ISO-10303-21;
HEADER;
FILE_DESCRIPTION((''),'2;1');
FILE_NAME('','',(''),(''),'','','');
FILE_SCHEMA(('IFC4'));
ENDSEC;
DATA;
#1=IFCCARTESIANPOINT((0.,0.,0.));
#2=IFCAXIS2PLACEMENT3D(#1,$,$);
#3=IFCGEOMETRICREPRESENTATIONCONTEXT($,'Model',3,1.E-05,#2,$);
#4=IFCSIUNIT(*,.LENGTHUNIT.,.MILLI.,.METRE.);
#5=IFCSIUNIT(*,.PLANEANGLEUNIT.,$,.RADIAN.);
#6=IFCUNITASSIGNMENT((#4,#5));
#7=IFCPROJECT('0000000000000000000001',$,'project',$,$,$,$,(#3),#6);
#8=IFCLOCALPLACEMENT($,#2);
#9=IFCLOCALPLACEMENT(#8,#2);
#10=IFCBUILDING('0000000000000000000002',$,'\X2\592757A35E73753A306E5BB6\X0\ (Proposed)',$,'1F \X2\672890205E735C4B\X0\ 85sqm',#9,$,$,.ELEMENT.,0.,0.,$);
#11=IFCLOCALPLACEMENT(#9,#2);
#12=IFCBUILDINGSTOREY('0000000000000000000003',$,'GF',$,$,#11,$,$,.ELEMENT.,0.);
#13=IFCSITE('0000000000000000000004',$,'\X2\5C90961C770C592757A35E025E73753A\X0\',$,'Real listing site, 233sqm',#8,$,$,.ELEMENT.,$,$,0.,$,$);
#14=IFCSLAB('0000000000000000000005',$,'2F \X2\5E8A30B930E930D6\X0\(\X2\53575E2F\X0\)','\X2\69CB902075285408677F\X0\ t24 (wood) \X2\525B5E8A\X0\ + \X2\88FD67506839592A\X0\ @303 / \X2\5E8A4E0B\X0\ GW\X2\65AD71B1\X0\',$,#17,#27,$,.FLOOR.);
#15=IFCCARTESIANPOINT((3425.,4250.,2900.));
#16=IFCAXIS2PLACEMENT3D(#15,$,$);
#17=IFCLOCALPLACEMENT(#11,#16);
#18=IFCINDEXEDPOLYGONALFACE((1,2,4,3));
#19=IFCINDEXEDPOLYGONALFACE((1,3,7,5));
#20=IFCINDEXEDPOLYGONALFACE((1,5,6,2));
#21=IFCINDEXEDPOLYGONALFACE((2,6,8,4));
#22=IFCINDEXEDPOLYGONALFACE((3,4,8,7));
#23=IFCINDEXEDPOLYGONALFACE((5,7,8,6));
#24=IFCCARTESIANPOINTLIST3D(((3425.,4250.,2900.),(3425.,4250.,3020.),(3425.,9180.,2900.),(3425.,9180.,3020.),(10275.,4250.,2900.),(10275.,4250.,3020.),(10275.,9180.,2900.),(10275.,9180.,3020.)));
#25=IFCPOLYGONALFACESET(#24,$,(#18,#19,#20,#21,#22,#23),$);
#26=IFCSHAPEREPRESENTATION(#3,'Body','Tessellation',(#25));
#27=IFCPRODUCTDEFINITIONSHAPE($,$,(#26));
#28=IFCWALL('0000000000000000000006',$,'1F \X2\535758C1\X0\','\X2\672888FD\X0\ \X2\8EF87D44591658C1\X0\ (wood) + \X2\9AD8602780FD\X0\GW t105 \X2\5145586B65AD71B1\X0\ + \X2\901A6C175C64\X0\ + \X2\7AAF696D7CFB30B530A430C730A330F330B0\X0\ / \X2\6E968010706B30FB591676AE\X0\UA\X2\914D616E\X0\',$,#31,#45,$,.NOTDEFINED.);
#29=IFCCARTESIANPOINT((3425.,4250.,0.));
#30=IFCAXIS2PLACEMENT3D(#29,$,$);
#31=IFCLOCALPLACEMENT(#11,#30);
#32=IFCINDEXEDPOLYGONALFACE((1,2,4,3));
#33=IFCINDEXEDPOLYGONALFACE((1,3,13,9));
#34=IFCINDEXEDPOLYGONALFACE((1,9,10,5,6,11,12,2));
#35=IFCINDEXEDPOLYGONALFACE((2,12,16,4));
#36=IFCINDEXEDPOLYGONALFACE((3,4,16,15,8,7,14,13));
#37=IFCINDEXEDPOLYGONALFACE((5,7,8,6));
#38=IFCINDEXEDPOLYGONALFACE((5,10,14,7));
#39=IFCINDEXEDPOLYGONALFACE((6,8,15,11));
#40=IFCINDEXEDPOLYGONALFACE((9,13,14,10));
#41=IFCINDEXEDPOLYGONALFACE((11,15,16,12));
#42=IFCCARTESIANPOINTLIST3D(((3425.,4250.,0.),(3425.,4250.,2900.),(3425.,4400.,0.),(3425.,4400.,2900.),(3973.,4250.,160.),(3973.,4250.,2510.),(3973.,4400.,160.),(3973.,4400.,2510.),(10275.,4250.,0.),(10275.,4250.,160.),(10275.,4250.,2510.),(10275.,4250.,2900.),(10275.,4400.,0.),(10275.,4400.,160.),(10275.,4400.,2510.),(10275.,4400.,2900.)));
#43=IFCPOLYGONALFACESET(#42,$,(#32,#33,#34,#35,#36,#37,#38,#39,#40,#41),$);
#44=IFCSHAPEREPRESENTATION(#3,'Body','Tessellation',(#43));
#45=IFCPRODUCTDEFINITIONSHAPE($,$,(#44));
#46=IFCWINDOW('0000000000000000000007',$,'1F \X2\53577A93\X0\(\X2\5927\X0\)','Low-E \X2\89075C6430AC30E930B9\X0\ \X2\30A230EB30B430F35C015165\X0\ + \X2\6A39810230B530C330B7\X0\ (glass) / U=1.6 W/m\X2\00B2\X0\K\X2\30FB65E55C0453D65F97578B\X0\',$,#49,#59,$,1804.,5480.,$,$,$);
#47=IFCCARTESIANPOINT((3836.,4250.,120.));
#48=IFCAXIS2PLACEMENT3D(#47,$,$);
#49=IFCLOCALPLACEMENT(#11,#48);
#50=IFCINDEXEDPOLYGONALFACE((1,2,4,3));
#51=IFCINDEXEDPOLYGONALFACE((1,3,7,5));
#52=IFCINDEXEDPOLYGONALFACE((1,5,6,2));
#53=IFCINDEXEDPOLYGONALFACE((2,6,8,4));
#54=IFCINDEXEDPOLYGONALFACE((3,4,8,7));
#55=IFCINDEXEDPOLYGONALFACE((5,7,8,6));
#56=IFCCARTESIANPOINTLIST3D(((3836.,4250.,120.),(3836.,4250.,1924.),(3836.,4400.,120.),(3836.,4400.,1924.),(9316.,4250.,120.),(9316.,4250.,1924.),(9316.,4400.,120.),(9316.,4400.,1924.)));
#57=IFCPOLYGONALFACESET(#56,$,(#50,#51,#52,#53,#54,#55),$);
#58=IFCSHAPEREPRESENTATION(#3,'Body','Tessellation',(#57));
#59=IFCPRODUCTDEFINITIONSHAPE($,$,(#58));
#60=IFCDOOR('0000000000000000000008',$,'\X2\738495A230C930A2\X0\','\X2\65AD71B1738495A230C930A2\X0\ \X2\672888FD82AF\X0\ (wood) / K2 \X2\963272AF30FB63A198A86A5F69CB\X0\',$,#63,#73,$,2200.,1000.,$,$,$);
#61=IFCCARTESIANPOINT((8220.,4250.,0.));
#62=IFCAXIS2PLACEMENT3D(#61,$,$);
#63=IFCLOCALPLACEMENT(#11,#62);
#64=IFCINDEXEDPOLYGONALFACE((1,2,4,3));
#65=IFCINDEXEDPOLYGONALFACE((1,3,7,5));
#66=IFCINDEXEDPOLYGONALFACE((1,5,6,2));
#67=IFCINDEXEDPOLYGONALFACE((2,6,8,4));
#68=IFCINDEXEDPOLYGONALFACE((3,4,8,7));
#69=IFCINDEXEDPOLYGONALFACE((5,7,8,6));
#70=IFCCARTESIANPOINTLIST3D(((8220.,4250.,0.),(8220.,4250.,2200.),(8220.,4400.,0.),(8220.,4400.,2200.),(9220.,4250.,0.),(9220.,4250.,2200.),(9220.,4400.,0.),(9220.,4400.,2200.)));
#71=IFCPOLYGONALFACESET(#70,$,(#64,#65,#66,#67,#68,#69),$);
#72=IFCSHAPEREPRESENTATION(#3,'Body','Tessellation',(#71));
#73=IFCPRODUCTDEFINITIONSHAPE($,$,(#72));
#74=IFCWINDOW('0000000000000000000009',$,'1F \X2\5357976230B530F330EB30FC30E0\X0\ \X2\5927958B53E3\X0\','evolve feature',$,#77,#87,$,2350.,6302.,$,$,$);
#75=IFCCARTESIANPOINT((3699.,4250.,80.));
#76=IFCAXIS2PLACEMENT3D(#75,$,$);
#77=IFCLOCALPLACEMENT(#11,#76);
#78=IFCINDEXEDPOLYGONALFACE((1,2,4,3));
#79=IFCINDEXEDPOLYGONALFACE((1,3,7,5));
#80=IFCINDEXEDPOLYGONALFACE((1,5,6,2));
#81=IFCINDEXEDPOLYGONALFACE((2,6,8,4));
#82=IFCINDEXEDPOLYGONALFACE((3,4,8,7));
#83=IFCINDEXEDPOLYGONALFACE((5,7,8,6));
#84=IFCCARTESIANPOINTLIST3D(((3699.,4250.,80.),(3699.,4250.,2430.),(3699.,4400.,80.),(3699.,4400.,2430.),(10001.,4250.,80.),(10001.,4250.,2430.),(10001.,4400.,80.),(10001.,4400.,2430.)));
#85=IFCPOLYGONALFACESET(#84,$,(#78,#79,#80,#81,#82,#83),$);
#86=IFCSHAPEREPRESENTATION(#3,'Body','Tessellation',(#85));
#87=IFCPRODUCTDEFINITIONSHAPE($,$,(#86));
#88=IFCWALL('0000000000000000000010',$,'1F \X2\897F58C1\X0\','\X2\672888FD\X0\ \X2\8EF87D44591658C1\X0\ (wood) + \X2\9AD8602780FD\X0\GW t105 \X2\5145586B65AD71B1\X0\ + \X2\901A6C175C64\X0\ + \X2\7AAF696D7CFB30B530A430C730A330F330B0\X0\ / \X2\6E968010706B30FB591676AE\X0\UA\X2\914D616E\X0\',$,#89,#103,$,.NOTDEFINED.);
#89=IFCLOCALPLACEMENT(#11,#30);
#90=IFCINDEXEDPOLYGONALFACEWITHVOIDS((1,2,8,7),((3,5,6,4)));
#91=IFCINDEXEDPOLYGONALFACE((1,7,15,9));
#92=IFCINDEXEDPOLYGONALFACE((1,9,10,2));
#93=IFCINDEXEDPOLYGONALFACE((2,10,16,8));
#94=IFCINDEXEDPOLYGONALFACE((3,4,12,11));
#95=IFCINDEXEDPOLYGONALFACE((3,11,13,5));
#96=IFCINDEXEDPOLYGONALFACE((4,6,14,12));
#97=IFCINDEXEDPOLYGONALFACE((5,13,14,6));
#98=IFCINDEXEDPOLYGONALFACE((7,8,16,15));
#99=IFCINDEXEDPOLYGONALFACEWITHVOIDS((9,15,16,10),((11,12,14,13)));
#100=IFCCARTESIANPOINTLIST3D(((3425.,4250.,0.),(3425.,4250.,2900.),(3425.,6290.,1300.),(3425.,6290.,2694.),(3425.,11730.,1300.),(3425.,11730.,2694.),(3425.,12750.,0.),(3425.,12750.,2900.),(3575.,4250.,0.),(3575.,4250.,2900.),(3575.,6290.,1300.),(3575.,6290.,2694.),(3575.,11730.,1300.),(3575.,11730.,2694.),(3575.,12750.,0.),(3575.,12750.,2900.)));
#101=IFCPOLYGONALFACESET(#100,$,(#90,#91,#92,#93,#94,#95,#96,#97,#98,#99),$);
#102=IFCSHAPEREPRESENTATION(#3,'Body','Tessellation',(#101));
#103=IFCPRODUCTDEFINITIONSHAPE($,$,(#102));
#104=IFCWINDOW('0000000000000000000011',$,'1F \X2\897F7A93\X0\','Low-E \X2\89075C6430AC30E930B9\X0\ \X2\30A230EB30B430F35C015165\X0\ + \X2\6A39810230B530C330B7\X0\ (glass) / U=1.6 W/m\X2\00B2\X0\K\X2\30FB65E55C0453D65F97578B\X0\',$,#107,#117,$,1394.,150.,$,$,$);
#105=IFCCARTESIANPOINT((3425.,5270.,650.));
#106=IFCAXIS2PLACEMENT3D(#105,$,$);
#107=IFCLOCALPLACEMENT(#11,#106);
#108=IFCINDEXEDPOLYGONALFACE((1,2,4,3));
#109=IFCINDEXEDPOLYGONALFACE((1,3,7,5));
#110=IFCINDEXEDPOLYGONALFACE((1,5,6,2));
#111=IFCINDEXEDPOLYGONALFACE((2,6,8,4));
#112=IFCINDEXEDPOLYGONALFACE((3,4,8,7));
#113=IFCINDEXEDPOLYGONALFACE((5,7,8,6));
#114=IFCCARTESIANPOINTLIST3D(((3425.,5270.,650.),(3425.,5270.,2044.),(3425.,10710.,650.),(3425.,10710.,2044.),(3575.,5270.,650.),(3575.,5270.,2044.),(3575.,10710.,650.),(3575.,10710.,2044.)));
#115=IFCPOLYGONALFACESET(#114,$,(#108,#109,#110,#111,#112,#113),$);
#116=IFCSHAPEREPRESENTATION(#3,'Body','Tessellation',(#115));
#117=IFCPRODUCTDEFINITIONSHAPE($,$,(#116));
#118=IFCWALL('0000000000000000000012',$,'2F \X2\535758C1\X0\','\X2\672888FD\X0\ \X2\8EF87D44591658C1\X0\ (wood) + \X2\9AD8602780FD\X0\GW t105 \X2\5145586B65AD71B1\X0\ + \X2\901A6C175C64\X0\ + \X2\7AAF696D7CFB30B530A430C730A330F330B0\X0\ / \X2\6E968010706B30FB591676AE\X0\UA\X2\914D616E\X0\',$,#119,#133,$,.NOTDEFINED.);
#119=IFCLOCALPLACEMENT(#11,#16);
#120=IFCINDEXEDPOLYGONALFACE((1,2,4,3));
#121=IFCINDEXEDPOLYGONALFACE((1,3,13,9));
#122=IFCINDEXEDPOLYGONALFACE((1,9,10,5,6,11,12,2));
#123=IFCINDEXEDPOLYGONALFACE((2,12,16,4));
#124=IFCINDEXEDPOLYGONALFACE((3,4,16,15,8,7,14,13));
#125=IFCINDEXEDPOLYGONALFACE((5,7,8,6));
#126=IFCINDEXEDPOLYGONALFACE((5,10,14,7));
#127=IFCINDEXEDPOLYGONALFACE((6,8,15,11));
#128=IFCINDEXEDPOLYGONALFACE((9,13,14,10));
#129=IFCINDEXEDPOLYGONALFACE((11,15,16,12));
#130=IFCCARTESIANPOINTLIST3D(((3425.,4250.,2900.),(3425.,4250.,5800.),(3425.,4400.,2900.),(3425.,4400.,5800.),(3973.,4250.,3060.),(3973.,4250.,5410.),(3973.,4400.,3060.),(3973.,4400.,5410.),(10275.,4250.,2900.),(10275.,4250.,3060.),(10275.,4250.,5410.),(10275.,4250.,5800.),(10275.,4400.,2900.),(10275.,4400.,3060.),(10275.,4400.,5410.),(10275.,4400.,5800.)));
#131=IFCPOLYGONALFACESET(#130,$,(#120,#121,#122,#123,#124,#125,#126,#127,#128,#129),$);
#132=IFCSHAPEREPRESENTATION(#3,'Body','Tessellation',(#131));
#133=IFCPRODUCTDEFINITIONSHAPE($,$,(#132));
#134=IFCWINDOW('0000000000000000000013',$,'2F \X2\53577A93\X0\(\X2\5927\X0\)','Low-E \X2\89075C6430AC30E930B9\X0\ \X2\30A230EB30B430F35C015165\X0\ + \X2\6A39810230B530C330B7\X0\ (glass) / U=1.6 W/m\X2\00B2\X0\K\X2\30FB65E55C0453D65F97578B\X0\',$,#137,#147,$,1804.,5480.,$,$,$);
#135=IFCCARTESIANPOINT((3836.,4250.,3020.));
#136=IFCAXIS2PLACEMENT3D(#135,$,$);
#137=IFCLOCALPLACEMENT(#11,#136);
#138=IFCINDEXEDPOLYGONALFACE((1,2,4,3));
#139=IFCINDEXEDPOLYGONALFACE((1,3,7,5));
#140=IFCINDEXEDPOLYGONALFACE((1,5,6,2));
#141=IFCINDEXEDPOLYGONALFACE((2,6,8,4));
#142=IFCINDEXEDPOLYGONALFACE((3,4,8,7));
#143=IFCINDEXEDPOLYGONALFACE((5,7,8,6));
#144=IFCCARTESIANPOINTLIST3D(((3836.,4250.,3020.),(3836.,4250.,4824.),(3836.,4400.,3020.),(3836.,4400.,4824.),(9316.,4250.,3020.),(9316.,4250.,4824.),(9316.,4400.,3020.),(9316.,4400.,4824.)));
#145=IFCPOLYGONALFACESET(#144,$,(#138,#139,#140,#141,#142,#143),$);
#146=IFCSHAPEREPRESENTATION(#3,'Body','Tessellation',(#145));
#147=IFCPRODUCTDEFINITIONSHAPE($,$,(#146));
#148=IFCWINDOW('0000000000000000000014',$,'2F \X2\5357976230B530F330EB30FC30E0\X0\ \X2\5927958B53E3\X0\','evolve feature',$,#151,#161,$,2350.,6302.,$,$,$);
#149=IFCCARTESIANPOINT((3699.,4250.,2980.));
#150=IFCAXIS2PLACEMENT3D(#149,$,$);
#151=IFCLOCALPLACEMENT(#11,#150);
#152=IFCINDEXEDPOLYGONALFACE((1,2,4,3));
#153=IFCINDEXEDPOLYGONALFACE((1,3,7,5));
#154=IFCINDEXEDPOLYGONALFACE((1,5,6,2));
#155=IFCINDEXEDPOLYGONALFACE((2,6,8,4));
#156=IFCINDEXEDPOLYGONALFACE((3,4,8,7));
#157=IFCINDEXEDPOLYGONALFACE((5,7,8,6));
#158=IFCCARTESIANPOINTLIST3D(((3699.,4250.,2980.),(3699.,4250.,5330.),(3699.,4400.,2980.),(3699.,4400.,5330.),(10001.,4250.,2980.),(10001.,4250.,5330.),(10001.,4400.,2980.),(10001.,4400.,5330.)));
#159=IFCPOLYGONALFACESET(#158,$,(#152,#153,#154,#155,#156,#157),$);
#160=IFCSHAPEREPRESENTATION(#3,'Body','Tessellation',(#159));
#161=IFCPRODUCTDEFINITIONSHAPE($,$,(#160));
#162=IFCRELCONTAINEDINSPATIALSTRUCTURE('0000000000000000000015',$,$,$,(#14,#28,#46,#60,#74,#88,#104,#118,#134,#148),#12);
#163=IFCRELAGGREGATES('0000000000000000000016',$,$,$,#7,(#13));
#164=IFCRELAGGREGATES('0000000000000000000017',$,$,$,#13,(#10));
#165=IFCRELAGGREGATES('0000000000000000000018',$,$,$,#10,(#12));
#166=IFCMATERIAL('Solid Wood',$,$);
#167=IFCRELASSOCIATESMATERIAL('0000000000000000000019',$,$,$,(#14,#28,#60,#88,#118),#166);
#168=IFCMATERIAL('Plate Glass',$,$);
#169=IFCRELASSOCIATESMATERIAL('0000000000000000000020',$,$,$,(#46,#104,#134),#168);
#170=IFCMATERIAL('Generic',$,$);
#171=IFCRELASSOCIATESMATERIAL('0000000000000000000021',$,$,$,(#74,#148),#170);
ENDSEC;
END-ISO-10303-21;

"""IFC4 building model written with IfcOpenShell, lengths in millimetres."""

from ifc_helpers import new_model, si_unit, frame, frame_2d, origin, place, context, project, spatial, rectangle, extrude, material, element, fill, save


model = new_model("IFC4")

# Units and contexts
model_context = context("Model", 3, precision=1e-05, world=origin())
ifc_project = project(units=[si_unit("LENGTHUNIT", "METRE", prefix="MILLI"), si_unit("PLANEANGLEUNIT", "RADIAN")], contexts=[model_context])

# Site, building, storey
site_placement = place(None, origin())
site = spatial("IfcSite", under=ifc_project, at=site_placement, Name="岐阜県大垣市平町", ObjectType="Real listing site, 233sqm", CompositionType="ELEMENT", RefElevation=0.0)
building_placement = place(site_placement, origin())
building = spatial("IfcBuilding", under=site, at=building_placement, Name="大垣平町の家 (Proposed)", ObjectType="1F 木造平屋 85sqm", CompositionType="ELEMENT", ElevationOfRefHeight=0.0, ElevationOfTerrain=0.0)
storey_placement = place(building_placement, origin())
storey = spatial("IfcBuildingStorey", under=building, at=storey_placement, Name="GF", CompositionType="ELEMENT", Elevation=0.0)

# Slab
ifc_material_1 = material(Name="Solid Wood")
slab_1_placement = place(storey_placement, frame((3425.0, 4250.0, 2900.0)))
element("IfcSlab", 1, at=slab_1_placement, inside=storey, material=ifc_material_1, Name="2F 床スラブ(南帯)", Description="構造用合板 t24 (wood) 剛床 + 製材根太 @303 / 床下 GW断熱", PredefinedType="FLOOR", context=model_context, shape_type="SweptSolid", body=[
    extrude(rectangle(XDim=6850.0, YDim=4930.0, at=frame_2d((3425.0, 2465.0))), frame((3425.0, 4250.0, 2900.0)), (0.0, 0.0, 1.0), 120.0),
])
ifc_material_2 = material(Name="Generic")

# Wall, openings, windows, door
wall_1_placement = place(storey_placement, frame((3425.0, 4250.0, 0.0)))
wall_1 = element("IfcWall", 2, at=wall_1_placement, inside=storey, material=ifc_material_1, Name="1F 南壁", Description="木製 軸組外壁 (wood) + 高性能GW t105 充填断熱 + 通気層 + 窯業系サイディング / 準耐火・外皮UA配慮", PredefinedType="NOTDEFINED", context=model_context, shape_type="SweptSolid", body=[
    extrude(rectangle(XDim=6850.0, YDim=150.0, at=frame_2d((3425.0, 75.0))), frame((3425.0, 4250.0, 0.0)), (0.0, 0.0, 1.0), 2900.0),
])
opening_1_placement = place(storey_placement, frame((3836.0, 4250.0, 120.0)))
opening_1 = element("IfcOpeningElement", 3, at=opening_1_placement, cuts=wall_1, PredefinedType="NOTDEFINED", context=model_context, shape_type="SweptSolid", body=[
    extrude(rectangle(XDim=5480.0, YDim=150.0, at=frame_2d((2740.0, 75.0))), frame((3836.0, 4250.0, 120.0)), (0.0, 0.0, 1.0), 1804.0),
])
opening_2_placement = place(storey_placement, frame((8220.0, 4250.0, 0.0)))
opening_2 = element("IfcOpeningElement", 4, at=opening_2_placement, cuts=wall_1, PredefinedType="NOTDEFINED", context=model_context, shape_type="SweptSolid", body=[
    extrude(rectangle(XDim=1000.0, YDim=150.0, at=frame_2d((500.0, 75.0))), frame((8220.0, 4250.0, 0.0)), (0.0, 0.0, 1.0), 2200.0),
])
opening_3_placement = place(storey_placement, frame((3699.0, 4250.0, 80.0)))
opening_3 = element("IfcOpeningElement", 5, at=opening_3_placement, cuts=wall_1, PredefinedType="NOTDEFINED", context=model_context, shape_type="SweptSolid", body=[
    extrude(rectangle(XDim=6302.0, YDim=150.0, at=frame_2d((3151.0, 75.0))), frame((3699.0, 4250.0, 80.0)), (0.0, 0.0, 1.0), 2350.0),
])
ifc_material_3 = material(Name="Plate Glass")
window_1_placement = place(storey_placement, frame((3836.0, 4250.0, 120.0)))
window_1 = element("IfcWindow", 6, at=window_1_placement, inside=storey, material=ifc_material_3, Name="1F 南窓(大)", Description="Low-E 複層ガラス アルゴン封入 + 樹脂サッシ (glass) / U=1.6 W/m²K・日射取得型", OverallHeight=1804.0, OverallWidth=5480.0, context=model_context, shape_type="SweptSolid", body=[
    extrude(rectangle(XDim=5480.0, YDim=150.0, at=frame_2d((2740.0, 75.0))), frame((3836.0, 4250.0, 120.0)), (0.0, 0.0, 1.0), 1804.0),
])
fill(opening_1, window_1)
door_placement = place(storey_placement, frame((8220.0, 4250.0, 0.0)))
door = element("IfcDoor", 7, at=door_placement, inside=storey, material=ifc_material_1, Name="玄関ドア", Description="断熱玄関ドア 木製芯 (wood) / K2 防犯・採風機構", OverallHeight=2200.0, OverallWidth=1000.0, context=model_context, shape_type="SweptSolid", body=[
    extrude(rectangle(XDim=1000.0, YDim=150.0, at=frame_2d((500.0, 75.0))), frame((8220.0, 4250.0, 0.0)), (0.0, 0.0, 1.0), 2200.0),
])
fill(opening_2, door)
window_2_placement = place(storey_placement, frame((3699.0, 4250.0, 80.0)))
window_2 = element("IfcWindow", 8, at=window_2_placement, inside=storey, material=ifc_material_2, Name="1F 南面サンルーム 大開口", Description="evolve feature", OverallHeight=2350.0, OverallWidth=6302.0, context=model_context, shape_type="SweptSolid", body=[
    extrude(rectangle(XDim=6302.0, YDim=150.0, at=frame_2d((3151.0, 75.0))), frame((3699.0, 4250.0, 80.0)), (0.0, 0.0, 1.0), 2350.0),
])
fill(opening_3, window_2)

# Wall, opening, window
wall_2_placement = place(storey_placement, frame((3425.0, 4250.0, 0.0)))
wall_2 = element("IfcWall", 9, at=wall_2_placement, inside=storey, material=ifc_material_1, Name="1F 西壁", Description="木製 軸組外壁 (wood) + 高性能GW t105 充填断熱 + 通気層 + 窯業系サイディング / 準耐火・外皮UA配慮", PredefinedType="NOTDEFINED", context=model_context, shape_type="SweptSolid", body=[
    extrude(rectangle(XDim=150.0, YDim=8500.0, at=frame_2d((75.0, 4250.0))), frame((3425.0, 4250.0, 0.0)), (0.0, 0.0, 1.0), 2900.0),
])
opening_4_placement = place(storey_placement, frame((3425.0, 5270.0, 650.0)))
opening_4 = element("IfcOpeningElement", 10, at=opening_4_placement, cuts=wall_2, PredefinedType="NOTDEFINED", context=model_context, shape_type="SweptSolid", body=[
    extrude(rectangle(XDim=150.0, YDim=5440.0, at=frame_2d((75.0, 2720.0))), frame((3425.0, 5270.0, 650.0)), (0.0, 0.0, 1.0), 1394.0),
])
window_3_placement = place(storey_placement, frame((3425.0, 5270.0, 650.0)))
window_3 = element("IfcWindow", 11, at=window_3_placement, inside=storey, material=ifc_material_3, Name="1F 西窓", Description="Low-E 複層ガラス アルゴン封入 + 樹脂サッシ (glass) / U=1.6 W/m²K・日射取得型", OverallHeight=1394.0, OverallWidth=150.0, context=model_context, shape_type="SweptSolid", body=[
    extrude(rectangle(XDim=150.0, YDim=5440.0, at=frame_2d((75.0, 2720.0))), frame((3425.0, 5270.0, 650.0)), (0.0, 0.0, 1.0), 1394.0),
])
fill(opening_4, window_3)

# Wall, openings, windows
wall_3_placement = place(storey_placement, frame((3425.0, 4250.0, 2900.0)))
wall_3 = element("IfcWall", 12, at=wall_3_placement, inside=storey, material=ifc_material_1, Name="2F 南壁", Description="木製 軸組外壁 (wood) + 高性能GW t105 充填断熱 + 通気層 + 窯業系サイディング / 準耐火・外皮UA配慮", PredefinedType="NOTDEFINED", context=model_context, shape_type="SweptSolid", body=[
    extrude(rectangle(XDim=6850.0, YDim=150.0, at=frame_2d((3425.0, 75.0))), frame((3425.0, 4250.0, 2900.0)), (0.0, 0.0, 1.0), 2900.0),
])
opening_5_placement = place(storey_placement, frame((3836.0, 4250.0, 3020.0)))
opening_5 = element("IfcOpeningElement", 13, at=opening_5_placement, cuts=wall_3, PredefinedType="NOTDEFINED", context=model_context, shape_type="SweptSolid", body=[
    extrude(rectangle(XDim=5480.0, YDim=150.0, at=frame_2d((2740.0, 75.0))), frame((3836.0, 4250.0, 3020.0)), (0.0, 0.0, 1.0), 1804.0),
])
opening_6_placement = place(storey_placement, frame((3699.0, 4250.0, 2980.0)))
opening_6 = element("IfcOpeningElement", 14, at=opening_6_placement, cuts=wall_3, PredefinedType="NOTDEFINED", context=model_context, shape_type="SweptSolid", body=[
    extrude(rectangle(XDim=6302.0, YDim=150.0, at=frame_2d((3151.0, 75.0))), frame((3699.0, 4250.0, 2980.0)), (0.0, 0.0, 1.0), 2350.0),
])
window_4_placement = place(storey_placement, frame((3836.0, 4250.0, 3020.0)))
window_4 = element("IfcWindow", 15, at=window_4_placement, inside=storey, material=ifc_material_3, Name="2F 南窓(大)", Description="Low-E 複層ガラス アルゴン封入 + 樹脂サッシ (glass) / U=1.6 W/m²K・日射取得型", OverallHeight=1804.0, OverallWidth=5480.0, context=model_context, shape_type="SweptSolid", body=[
    extrude(rectangle(XDim=5480.0, YDim=150.0, at=frame_2d((2740.0, 75.0))), frame((3836.0, 4250.0, 3020.0)), (0.0, 0.0, 1.0), 1804.0),
])
fill(opening_5, window_4)
window_5_placement = place(storey_placement, frame((3699.0, 4250.0, 2980.0)))
window_5 = element("IfcWindow", 16, at=window_5_placement, inside=storey, material=ifc_material_2, Name="2F 南面サンルーム 大開口", Description="evolve feature", OverallHeight=2350.0, OverallWidth=6302.0, context=model_context, shape_type="SweptSolid", body=[
    extrude(rectangle(XDim=6302.0, YDim=150.0, at=frame_2d((3151.0, 75.0))), frame((3699.0, 4250.0, 2980.0)), (0.0, 0.0, 1.0), 2350.0),
])
fill(opening_6, window_5)

save(model, "model.ifc")
